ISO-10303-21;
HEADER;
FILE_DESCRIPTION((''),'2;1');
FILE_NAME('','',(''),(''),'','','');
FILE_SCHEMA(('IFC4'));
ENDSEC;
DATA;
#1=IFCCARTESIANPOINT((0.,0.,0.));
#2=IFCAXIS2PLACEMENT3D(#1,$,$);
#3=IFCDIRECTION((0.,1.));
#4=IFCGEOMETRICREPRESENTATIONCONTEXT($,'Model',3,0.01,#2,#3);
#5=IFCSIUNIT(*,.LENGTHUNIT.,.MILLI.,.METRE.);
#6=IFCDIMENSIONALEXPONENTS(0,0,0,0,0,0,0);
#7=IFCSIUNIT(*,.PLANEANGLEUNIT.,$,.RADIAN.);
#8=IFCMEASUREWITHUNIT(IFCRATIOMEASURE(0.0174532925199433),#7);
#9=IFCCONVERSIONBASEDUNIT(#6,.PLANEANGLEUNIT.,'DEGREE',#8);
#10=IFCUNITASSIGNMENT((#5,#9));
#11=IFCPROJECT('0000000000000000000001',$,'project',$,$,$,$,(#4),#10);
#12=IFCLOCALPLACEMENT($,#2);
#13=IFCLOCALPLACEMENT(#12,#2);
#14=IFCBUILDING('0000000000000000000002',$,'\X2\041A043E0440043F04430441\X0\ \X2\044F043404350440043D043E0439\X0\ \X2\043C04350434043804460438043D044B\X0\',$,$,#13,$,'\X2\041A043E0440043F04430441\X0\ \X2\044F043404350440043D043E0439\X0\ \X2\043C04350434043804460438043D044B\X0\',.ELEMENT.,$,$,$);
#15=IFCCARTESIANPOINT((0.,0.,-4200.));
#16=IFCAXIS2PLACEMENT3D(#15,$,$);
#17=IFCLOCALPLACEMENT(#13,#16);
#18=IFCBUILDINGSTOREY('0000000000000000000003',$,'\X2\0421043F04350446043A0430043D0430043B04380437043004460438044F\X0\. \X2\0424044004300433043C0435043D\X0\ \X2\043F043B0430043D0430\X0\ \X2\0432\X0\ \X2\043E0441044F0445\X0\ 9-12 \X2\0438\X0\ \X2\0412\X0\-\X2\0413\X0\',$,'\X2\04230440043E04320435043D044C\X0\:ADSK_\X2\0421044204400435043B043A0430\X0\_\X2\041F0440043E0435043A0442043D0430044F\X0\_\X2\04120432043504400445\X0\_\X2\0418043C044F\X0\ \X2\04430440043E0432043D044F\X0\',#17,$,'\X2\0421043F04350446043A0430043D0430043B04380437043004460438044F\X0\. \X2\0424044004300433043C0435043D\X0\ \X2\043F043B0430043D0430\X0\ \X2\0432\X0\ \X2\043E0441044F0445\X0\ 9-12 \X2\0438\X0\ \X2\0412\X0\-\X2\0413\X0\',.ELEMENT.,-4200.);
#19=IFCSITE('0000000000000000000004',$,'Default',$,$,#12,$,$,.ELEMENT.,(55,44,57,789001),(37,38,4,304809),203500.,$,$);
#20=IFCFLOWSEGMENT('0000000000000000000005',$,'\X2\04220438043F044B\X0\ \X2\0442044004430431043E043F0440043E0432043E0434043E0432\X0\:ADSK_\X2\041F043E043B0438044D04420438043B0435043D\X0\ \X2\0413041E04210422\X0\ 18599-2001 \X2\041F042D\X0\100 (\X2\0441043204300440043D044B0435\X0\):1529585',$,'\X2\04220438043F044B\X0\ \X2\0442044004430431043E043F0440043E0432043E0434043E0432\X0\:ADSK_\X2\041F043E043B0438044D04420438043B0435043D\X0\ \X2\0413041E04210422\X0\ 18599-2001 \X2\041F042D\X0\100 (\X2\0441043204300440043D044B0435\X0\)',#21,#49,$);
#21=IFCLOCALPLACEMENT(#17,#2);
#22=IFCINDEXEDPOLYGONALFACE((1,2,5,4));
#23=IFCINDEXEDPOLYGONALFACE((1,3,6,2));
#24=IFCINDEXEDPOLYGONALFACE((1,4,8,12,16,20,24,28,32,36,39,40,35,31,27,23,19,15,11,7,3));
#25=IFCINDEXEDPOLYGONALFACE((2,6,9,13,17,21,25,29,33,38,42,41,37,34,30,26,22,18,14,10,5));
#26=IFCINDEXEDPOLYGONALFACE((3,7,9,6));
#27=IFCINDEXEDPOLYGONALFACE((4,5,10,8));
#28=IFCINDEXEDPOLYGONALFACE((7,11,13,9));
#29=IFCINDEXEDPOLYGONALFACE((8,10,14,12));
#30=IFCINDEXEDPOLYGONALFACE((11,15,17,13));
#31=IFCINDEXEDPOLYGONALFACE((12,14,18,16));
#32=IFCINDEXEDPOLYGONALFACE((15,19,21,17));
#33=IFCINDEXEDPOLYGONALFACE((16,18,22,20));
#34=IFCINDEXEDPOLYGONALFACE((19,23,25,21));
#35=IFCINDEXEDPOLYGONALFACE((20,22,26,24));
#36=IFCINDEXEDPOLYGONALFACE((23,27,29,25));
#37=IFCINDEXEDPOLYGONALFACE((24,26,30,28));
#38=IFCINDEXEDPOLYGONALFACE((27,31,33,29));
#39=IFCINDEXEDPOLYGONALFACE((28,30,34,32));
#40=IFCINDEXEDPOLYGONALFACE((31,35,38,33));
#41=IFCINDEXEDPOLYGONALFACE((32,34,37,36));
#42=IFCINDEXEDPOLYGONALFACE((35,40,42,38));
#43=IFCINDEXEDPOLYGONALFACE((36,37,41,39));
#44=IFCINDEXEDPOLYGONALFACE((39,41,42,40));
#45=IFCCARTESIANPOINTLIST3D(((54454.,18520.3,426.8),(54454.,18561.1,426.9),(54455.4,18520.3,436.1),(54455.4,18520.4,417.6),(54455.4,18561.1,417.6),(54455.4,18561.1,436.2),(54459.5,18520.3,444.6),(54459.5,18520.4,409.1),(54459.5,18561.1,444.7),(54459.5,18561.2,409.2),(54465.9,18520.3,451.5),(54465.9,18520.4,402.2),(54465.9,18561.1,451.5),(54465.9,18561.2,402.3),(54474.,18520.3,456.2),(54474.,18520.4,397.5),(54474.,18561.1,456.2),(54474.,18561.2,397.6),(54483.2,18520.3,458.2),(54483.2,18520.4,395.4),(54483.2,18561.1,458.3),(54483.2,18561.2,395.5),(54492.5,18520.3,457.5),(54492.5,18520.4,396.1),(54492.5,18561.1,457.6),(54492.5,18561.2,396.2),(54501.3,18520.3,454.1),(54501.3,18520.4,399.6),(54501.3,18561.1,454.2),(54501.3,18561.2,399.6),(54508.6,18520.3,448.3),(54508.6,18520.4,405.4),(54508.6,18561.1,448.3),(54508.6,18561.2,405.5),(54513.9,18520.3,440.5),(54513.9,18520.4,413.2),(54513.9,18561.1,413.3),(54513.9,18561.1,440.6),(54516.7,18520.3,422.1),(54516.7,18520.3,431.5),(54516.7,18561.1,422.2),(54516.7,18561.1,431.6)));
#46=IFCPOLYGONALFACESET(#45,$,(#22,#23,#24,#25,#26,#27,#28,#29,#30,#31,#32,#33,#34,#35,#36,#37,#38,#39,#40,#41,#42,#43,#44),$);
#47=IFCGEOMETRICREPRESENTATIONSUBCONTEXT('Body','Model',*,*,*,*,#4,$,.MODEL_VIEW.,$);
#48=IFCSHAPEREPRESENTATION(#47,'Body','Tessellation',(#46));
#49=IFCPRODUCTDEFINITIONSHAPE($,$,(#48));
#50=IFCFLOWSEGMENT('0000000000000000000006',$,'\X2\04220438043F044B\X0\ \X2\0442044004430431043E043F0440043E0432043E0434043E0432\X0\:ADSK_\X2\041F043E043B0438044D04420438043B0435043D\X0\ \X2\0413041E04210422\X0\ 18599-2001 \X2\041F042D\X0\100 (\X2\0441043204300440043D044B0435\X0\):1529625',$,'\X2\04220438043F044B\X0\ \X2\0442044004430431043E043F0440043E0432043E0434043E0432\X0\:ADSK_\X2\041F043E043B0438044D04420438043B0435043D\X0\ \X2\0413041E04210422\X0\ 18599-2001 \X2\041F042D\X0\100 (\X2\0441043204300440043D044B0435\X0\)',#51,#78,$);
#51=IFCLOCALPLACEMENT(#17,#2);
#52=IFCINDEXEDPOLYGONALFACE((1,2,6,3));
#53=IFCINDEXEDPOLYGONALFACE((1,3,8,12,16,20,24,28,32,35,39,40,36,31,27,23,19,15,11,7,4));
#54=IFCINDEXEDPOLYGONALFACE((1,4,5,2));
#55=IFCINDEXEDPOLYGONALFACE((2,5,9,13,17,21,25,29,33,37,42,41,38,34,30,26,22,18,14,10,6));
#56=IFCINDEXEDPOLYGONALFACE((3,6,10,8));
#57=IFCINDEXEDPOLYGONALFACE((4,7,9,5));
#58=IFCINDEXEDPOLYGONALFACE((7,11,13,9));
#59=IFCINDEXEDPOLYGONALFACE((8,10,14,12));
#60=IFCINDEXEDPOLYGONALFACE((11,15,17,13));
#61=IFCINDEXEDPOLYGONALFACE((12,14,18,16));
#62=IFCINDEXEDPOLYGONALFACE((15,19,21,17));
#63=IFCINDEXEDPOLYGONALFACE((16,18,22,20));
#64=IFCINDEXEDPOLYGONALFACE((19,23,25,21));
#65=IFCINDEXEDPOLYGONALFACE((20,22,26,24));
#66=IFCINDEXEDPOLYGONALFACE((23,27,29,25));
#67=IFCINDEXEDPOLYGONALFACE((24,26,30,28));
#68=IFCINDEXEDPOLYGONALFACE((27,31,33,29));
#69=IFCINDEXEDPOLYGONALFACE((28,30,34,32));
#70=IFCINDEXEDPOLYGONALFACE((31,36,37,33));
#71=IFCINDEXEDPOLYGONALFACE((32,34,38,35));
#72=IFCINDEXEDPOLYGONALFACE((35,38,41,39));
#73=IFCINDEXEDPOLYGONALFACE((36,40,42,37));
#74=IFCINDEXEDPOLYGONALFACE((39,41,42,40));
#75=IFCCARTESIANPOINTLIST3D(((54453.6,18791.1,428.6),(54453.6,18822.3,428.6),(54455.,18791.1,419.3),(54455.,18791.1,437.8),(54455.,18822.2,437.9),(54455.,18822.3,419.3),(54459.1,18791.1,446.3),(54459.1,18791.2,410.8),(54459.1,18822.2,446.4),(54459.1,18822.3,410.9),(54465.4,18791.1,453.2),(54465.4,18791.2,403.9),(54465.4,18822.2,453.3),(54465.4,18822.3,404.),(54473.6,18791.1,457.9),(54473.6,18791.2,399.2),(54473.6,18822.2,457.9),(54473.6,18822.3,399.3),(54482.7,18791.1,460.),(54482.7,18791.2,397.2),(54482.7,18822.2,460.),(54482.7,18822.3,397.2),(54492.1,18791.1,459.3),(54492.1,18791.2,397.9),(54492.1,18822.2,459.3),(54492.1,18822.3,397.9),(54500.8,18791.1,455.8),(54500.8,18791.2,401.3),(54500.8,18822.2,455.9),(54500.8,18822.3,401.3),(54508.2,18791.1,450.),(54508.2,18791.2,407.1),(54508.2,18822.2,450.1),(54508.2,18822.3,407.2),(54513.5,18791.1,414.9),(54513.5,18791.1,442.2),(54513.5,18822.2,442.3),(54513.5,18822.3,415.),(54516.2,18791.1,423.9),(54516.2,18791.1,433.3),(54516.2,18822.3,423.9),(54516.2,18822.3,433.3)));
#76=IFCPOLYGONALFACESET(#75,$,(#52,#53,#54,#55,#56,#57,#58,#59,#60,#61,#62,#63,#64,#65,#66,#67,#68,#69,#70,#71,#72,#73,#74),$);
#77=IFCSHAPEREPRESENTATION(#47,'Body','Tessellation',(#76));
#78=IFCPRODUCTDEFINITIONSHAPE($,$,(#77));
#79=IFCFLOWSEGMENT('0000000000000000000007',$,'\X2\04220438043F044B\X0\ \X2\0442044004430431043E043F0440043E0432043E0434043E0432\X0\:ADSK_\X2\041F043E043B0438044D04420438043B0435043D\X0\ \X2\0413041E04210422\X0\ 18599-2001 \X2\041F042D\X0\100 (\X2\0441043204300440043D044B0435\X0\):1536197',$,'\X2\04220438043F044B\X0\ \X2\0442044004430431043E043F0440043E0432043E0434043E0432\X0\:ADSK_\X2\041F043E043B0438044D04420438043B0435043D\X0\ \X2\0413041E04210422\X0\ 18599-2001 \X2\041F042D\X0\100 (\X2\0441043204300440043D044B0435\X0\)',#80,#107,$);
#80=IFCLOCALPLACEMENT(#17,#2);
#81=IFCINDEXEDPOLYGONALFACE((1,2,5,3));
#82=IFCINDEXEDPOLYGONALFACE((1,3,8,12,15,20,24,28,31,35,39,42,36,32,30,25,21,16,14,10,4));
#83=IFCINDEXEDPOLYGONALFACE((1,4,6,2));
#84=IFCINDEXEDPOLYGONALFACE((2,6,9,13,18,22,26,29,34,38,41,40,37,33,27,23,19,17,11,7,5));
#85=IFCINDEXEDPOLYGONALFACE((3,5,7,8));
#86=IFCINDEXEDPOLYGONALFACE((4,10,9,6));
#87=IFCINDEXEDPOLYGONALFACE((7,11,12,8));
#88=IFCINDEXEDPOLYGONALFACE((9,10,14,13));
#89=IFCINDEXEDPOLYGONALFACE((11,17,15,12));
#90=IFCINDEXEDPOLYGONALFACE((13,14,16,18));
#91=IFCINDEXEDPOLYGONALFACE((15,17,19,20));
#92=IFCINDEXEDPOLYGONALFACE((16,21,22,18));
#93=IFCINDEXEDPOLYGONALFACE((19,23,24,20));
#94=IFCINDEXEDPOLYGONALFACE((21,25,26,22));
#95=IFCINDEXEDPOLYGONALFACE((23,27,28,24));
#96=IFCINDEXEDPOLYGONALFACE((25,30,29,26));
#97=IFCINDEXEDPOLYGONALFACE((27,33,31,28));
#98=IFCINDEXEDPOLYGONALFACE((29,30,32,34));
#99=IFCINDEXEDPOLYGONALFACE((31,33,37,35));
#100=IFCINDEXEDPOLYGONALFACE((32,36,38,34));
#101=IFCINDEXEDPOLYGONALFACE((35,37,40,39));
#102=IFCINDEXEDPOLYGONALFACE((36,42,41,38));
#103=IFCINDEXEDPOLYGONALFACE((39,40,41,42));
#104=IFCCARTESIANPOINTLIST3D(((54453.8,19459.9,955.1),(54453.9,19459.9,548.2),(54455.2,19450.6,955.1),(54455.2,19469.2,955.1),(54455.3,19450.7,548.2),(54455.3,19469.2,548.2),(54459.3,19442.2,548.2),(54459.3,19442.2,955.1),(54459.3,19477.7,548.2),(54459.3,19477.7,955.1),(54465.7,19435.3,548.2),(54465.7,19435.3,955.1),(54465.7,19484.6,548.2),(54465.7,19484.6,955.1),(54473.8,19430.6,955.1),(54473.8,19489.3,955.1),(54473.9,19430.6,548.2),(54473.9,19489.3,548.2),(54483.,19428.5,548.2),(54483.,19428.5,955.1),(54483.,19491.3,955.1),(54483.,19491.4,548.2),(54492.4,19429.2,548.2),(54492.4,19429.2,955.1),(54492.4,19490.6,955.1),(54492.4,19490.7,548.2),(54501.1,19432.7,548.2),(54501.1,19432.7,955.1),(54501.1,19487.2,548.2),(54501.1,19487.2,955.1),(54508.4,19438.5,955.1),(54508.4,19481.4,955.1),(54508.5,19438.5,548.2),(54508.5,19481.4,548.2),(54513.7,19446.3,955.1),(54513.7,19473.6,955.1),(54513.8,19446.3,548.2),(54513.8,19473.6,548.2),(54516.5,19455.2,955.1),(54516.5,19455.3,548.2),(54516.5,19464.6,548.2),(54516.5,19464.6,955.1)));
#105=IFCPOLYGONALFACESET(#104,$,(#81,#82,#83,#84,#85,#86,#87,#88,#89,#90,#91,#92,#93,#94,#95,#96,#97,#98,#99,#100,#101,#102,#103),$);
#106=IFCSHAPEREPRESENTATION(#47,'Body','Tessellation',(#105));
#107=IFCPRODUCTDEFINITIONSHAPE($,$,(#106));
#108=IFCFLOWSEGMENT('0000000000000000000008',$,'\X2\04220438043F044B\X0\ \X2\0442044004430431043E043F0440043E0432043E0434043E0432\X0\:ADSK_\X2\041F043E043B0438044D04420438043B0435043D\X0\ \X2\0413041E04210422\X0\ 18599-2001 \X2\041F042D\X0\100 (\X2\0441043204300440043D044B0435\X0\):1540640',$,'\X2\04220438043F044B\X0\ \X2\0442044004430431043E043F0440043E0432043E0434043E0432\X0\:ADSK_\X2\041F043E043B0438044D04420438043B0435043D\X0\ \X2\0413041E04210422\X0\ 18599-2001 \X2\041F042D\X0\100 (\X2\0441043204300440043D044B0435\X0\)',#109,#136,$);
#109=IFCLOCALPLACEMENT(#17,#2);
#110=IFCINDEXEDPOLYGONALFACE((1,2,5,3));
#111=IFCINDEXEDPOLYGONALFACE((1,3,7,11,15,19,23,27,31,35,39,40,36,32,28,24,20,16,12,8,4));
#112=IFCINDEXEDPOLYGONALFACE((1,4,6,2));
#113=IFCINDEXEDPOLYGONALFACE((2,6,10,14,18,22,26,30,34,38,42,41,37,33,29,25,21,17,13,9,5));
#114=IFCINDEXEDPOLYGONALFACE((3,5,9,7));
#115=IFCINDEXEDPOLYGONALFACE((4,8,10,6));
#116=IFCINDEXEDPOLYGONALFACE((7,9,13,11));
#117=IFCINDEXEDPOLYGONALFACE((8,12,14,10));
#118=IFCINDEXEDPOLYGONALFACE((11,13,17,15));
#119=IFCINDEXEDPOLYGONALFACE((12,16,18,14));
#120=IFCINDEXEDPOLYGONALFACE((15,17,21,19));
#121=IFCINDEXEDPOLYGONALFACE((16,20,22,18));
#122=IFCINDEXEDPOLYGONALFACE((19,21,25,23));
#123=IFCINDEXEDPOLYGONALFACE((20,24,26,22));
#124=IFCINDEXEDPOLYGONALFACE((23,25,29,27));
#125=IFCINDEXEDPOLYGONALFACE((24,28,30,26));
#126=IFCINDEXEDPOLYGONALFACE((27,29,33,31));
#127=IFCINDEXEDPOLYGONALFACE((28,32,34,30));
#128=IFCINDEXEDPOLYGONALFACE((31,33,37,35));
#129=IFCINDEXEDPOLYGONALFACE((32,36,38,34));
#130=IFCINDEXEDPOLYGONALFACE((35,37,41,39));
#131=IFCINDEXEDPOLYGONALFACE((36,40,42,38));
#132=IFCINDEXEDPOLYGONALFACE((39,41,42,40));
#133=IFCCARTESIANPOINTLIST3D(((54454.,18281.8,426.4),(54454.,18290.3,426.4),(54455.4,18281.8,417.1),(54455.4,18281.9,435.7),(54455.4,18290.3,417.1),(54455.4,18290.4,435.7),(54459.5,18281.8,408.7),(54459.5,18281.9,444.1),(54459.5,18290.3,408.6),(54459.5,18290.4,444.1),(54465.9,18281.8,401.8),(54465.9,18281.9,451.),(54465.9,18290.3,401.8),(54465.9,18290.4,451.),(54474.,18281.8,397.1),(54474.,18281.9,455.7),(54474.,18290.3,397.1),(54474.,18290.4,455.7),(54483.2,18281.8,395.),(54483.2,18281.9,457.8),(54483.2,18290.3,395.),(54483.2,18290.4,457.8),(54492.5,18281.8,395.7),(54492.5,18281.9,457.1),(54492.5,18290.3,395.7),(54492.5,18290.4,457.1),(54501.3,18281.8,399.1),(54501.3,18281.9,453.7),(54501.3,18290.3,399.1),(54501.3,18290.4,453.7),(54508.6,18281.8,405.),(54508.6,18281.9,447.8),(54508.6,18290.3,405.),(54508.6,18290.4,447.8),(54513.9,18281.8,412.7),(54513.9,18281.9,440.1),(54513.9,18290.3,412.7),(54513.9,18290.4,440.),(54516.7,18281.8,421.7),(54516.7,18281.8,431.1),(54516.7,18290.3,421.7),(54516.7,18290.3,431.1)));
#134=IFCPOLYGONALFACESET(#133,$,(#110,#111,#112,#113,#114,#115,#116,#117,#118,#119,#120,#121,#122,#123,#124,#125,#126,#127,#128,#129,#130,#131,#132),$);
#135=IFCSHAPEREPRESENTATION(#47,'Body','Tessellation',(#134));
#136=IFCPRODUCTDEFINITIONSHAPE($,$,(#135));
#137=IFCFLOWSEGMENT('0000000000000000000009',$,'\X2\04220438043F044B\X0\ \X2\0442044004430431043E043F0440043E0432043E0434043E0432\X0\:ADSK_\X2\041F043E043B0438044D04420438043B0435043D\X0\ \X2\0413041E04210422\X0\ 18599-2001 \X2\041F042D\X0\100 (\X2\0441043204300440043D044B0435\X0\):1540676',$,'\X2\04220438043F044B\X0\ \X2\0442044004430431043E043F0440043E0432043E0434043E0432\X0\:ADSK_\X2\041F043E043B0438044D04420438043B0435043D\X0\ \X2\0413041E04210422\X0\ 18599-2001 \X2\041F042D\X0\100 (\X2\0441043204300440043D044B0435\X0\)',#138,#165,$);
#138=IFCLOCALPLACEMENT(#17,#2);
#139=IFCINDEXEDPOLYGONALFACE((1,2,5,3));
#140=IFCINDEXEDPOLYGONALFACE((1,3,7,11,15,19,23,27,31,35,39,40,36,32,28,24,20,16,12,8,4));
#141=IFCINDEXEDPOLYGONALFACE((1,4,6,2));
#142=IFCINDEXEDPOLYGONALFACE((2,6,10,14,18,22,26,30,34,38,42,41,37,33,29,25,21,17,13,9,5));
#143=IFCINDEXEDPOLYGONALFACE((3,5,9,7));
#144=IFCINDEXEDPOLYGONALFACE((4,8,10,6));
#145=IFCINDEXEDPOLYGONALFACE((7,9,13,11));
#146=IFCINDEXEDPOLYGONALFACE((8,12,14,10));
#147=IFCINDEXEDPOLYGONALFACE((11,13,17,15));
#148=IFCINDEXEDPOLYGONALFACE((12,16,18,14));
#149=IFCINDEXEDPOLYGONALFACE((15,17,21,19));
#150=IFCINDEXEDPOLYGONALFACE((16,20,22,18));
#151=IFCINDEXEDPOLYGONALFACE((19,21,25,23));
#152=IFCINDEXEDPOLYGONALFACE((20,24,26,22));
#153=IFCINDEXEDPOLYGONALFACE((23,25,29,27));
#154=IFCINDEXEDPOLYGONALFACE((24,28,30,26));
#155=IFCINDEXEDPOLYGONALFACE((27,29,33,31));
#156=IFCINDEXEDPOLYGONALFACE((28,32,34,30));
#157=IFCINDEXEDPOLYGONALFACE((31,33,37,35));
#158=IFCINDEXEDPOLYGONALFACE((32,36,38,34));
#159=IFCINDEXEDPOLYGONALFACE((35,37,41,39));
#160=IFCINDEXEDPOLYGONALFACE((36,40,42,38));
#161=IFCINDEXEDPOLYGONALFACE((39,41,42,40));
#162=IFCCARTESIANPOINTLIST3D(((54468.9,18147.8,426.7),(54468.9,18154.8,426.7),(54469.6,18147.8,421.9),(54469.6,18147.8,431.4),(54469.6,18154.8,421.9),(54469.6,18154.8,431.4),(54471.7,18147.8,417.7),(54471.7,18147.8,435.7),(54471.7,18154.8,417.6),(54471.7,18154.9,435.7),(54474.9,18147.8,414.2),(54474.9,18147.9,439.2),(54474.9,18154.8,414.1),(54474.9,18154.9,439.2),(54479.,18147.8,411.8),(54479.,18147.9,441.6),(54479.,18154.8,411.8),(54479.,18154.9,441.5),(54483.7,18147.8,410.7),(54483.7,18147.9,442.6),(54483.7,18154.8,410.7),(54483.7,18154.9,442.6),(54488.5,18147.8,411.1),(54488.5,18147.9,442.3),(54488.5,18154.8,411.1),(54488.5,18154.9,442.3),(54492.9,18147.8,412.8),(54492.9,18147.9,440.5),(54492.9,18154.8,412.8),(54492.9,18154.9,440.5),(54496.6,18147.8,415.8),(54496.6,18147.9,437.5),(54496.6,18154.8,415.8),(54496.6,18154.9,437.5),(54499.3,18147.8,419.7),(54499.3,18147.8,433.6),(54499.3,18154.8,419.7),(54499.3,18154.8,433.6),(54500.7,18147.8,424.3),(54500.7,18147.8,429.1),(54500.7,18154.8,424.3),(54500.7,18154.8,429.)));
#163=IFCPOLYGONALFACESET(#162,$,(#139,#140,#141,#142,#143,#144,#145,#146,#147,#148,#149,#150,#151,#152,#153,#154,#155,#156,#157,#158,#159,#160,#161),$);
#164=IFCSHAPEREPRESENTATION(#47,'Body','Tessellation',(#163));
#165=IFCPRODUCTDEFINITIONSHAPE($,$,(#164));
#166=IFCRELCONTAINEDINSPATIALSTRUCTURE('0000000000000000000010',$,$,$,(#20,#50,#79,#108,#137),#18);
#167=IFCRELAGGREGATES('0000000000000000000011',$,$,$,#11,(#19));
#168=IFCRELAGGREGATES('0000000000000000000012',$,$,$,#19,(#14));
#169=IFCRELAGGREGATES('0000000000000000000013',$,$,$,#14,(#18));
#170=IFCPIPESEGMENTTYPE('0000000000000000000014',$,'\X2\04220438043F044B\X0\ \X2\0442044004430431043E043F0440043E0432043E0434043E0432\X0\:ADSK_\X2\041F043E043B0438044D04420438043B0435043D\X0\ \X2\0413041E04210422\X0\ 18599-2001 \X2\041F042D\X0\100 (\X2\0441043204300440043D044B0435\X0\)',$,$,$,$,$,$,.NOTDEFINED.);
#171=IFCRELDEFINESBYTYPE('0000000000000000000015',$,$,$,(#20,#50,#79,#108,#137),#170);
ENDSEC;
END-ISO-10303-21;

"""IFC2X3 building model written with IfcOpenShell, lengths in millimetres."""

from ifc_helpers import new_model, entity, si_unit, converted_unit, direction, frame, frame_2d, origin, origin_2d_with_axis, place, context, subcontext, project, spatial, circle, extrude, type_object, element, save


model = new_model("IFC2X3")

# Units and contexts
model_context = context("Model", 3, precision=0.01, world=origin(), true_north=direction((0.0, 1.0)))
body_context = subcontext(model_context, "Body", "Model", "MODEL_VIEW")
ifc_project = project(units=[si_unit("LENGTHUNIT", "METRE", prefix="MILLI"), converted_unit("PLANEANGLEUNIT", "DEGREE", entity("IfcRatioMeasure", 0.0174532925199433), si_unit("PLANEANGLEUNIT", "RADIAN"), dimensions=[0, 0, 0, 0, 0, 0, 0])], contexts=[model_context])

# Site, building, storey
site_placement = place(None, frame((0.0, 0.0, 0.0)))
site = spatial("IfcSite", under=ifc_project, at=site_placement, Name="Default", CompositionType="ELEMENT", RefLatitude=(55, 44, 57, 789001), RefLongitude=(37, 38, 4, 304809), RefElevation=203500.0)
building_placement = place(site_placement, origin())
building = spatial("IfcBuilding", under=site, at=building_placement, Name="Корпус ядерной медицины", LongName="Корпус ядерной медицины", CompositionType="ELEMENT")
storey_placement = place(building_placement, frame((0.0, 0.0, -4200.0)))
storey = spatial("IfcBuildingStorey", under=building, at=storey_placement, Name="Спецканализация. Фрагмен плана в осях 9-12 и В-Г", ObjectType="Уровень:ADSK_Стрелка_Проектная_Вверх_Имя уровня", LongName="Спецканализация. Фрагмен плана в осях 9-12 и В-Г", CompositionType="ELEMENT", Elevation=-4200.0)

# Flow segments
pipe_segment_type = type_object("IfcPipeSegmentType", Name="Типы трубопроводов:ADSK_Полиэтилен ГОСТ 18599-2001 ПЭ100 (сварные)", PredefinedType="NOTDEFINED")
flow_segment_1_placement = place(storey_placement, frame((54452.4, 18520.3, 393.7)))
element("IfcFlowSegment", 1, at=flow_segment_1_placement, inside=storey, type_object=pipe_segment_type, Name="Типы трубопроводов:ADSK_Полиэтилен ГОСТ 18599-2001 ПЭ100 (сварные):1529585", ObjectType="Типы трубопроводов:ADSK_Полиэтилен ГОСТ 18599-2001 ПЭ100 (сварные)", context=body_context, shape_type="SweptSolid", body=[
    extrude(circle(Radius=31.5, at=frame_2d((0.0, 0.0), x_axis=(1.0, 0.0))), frame((33.1, 0.1, 33.1), z_axis=(0.0, 0.999998, 0.001978), x_axis=(-1.0, 0.0, 0.0)), (0.0, 0.0, 1.0), 40.8),
])
flow_segment_2_placement = place(storey_placement, frame((54452.0, 18791.1, 395.5)))
element("IfcFlowSegment", 2, at=flow_segment_2_placement, inside=storey, type_object=pipe_segment_type, Name="Типы трубопроводов:ADSK_Полиэтилен ГОСТ 18599-2001 ПЭ100 (сварные):1529625", ObjectType="Типы трубопроводов:ADSK_Полиэтилен ГОСТ 18599-2001 ПЭ100 (сварные)", context=body_context, shape_type="SweptSolid", body=[
    extrude(circle(Radius=31.5, at=origin_2d_with_axis()), frame((33.1, 0.1, 33.1), z_axis=(0.0, 0.999998, 0.001978), x_axis=(-1.0, 0.0, 0.0)), (0.0, 0.0, 1.0), 31.1),
])
flow_segment_3_placement = place(storey_placement, frame((54452.3, 19426.8, 548.2)))
element("IfcFlowSegment", 3, at=flow_segment_3_placement, inside=storey, type_object=pipe_segment_type, Name="Типы трубопроводов:ADSK_Полиэтилен ГОСТ 18599-2001 ПЭ100 (сварные):1536197", ObjectType="Типы трубопроводов:ADSK_Полиэтилен ГОСТ 18599-2001 ПЭ100 (сварные)", context=body_context, shape_type="SweptSolid", body=[
    extrude(circle(Radius=31.5, at=origin_2d_with_axis()), frame((33.1, 33.1, 0.0), z_axis=(-0.000061, -0.000031, 1.0), x_axis=(-1.0, 0.0, -0.000061)), (0.0, 0.0, 1.0), 406.9),
])
flow_segment_4_placement = place(storey_placement, frame((54452.4, 18281.8, 393.3)))
element("IfcFlowSegment", 4, at=flow_segment_4_placement, inside=storey, type_object=pipe_segment_type, Name="Типы трубопроводов:ADSK_Полиэтилен ГОСТ 18599-2001 ПЭ100 (сварные):1540640", ObjectType="Типы трубопроводов:ADSK_Полиэтилен ГОСТ 18599-2001 ПЭ100 (сварные)", context=body_context, shape_type="SweptSolid", body=[
    extrude(circle(Radius=31.5, at=origin_2d_with_axis()), frame((33.1, 8.6, 33.1), z_axis=(0.0, -0.999998, 0.002), x_axis=(-1.0, 0.0, 0.0)), (0.0, 0.0, 1.0), 8.5),
])
flow_segment_5_placement = place(storey_placement, frame((54467.3, 18147.8, 409.1)))
element("IfcFlowSegment", 5, at=flow_segment_5_placement, inside=storey, type_object=pipe_segment_type, Name="Типы трубопроводов:ADSK_Полиэтилен ГОСТ 18599-2001 ПЭ100 (сварные):1540676", ObjectType="Типы трубопроводов:ADSK_Полиэтилен ГОСТ 18599-2001 ПЭ100 (сварные)", context=body_context, shape_type="SweptSolid", body=[
    extrude(circle(Radius=16.0, at=origin_2d_with_axis()), frame((17.6, 7.0, 17.6), z_axis=(0.0, -0.999998, 0.002), x_axis=(-1.0, 0.0, 0.0)), (0.0, 0.0, 1.0), 7.0),
])

save(model, "model.ifc")
